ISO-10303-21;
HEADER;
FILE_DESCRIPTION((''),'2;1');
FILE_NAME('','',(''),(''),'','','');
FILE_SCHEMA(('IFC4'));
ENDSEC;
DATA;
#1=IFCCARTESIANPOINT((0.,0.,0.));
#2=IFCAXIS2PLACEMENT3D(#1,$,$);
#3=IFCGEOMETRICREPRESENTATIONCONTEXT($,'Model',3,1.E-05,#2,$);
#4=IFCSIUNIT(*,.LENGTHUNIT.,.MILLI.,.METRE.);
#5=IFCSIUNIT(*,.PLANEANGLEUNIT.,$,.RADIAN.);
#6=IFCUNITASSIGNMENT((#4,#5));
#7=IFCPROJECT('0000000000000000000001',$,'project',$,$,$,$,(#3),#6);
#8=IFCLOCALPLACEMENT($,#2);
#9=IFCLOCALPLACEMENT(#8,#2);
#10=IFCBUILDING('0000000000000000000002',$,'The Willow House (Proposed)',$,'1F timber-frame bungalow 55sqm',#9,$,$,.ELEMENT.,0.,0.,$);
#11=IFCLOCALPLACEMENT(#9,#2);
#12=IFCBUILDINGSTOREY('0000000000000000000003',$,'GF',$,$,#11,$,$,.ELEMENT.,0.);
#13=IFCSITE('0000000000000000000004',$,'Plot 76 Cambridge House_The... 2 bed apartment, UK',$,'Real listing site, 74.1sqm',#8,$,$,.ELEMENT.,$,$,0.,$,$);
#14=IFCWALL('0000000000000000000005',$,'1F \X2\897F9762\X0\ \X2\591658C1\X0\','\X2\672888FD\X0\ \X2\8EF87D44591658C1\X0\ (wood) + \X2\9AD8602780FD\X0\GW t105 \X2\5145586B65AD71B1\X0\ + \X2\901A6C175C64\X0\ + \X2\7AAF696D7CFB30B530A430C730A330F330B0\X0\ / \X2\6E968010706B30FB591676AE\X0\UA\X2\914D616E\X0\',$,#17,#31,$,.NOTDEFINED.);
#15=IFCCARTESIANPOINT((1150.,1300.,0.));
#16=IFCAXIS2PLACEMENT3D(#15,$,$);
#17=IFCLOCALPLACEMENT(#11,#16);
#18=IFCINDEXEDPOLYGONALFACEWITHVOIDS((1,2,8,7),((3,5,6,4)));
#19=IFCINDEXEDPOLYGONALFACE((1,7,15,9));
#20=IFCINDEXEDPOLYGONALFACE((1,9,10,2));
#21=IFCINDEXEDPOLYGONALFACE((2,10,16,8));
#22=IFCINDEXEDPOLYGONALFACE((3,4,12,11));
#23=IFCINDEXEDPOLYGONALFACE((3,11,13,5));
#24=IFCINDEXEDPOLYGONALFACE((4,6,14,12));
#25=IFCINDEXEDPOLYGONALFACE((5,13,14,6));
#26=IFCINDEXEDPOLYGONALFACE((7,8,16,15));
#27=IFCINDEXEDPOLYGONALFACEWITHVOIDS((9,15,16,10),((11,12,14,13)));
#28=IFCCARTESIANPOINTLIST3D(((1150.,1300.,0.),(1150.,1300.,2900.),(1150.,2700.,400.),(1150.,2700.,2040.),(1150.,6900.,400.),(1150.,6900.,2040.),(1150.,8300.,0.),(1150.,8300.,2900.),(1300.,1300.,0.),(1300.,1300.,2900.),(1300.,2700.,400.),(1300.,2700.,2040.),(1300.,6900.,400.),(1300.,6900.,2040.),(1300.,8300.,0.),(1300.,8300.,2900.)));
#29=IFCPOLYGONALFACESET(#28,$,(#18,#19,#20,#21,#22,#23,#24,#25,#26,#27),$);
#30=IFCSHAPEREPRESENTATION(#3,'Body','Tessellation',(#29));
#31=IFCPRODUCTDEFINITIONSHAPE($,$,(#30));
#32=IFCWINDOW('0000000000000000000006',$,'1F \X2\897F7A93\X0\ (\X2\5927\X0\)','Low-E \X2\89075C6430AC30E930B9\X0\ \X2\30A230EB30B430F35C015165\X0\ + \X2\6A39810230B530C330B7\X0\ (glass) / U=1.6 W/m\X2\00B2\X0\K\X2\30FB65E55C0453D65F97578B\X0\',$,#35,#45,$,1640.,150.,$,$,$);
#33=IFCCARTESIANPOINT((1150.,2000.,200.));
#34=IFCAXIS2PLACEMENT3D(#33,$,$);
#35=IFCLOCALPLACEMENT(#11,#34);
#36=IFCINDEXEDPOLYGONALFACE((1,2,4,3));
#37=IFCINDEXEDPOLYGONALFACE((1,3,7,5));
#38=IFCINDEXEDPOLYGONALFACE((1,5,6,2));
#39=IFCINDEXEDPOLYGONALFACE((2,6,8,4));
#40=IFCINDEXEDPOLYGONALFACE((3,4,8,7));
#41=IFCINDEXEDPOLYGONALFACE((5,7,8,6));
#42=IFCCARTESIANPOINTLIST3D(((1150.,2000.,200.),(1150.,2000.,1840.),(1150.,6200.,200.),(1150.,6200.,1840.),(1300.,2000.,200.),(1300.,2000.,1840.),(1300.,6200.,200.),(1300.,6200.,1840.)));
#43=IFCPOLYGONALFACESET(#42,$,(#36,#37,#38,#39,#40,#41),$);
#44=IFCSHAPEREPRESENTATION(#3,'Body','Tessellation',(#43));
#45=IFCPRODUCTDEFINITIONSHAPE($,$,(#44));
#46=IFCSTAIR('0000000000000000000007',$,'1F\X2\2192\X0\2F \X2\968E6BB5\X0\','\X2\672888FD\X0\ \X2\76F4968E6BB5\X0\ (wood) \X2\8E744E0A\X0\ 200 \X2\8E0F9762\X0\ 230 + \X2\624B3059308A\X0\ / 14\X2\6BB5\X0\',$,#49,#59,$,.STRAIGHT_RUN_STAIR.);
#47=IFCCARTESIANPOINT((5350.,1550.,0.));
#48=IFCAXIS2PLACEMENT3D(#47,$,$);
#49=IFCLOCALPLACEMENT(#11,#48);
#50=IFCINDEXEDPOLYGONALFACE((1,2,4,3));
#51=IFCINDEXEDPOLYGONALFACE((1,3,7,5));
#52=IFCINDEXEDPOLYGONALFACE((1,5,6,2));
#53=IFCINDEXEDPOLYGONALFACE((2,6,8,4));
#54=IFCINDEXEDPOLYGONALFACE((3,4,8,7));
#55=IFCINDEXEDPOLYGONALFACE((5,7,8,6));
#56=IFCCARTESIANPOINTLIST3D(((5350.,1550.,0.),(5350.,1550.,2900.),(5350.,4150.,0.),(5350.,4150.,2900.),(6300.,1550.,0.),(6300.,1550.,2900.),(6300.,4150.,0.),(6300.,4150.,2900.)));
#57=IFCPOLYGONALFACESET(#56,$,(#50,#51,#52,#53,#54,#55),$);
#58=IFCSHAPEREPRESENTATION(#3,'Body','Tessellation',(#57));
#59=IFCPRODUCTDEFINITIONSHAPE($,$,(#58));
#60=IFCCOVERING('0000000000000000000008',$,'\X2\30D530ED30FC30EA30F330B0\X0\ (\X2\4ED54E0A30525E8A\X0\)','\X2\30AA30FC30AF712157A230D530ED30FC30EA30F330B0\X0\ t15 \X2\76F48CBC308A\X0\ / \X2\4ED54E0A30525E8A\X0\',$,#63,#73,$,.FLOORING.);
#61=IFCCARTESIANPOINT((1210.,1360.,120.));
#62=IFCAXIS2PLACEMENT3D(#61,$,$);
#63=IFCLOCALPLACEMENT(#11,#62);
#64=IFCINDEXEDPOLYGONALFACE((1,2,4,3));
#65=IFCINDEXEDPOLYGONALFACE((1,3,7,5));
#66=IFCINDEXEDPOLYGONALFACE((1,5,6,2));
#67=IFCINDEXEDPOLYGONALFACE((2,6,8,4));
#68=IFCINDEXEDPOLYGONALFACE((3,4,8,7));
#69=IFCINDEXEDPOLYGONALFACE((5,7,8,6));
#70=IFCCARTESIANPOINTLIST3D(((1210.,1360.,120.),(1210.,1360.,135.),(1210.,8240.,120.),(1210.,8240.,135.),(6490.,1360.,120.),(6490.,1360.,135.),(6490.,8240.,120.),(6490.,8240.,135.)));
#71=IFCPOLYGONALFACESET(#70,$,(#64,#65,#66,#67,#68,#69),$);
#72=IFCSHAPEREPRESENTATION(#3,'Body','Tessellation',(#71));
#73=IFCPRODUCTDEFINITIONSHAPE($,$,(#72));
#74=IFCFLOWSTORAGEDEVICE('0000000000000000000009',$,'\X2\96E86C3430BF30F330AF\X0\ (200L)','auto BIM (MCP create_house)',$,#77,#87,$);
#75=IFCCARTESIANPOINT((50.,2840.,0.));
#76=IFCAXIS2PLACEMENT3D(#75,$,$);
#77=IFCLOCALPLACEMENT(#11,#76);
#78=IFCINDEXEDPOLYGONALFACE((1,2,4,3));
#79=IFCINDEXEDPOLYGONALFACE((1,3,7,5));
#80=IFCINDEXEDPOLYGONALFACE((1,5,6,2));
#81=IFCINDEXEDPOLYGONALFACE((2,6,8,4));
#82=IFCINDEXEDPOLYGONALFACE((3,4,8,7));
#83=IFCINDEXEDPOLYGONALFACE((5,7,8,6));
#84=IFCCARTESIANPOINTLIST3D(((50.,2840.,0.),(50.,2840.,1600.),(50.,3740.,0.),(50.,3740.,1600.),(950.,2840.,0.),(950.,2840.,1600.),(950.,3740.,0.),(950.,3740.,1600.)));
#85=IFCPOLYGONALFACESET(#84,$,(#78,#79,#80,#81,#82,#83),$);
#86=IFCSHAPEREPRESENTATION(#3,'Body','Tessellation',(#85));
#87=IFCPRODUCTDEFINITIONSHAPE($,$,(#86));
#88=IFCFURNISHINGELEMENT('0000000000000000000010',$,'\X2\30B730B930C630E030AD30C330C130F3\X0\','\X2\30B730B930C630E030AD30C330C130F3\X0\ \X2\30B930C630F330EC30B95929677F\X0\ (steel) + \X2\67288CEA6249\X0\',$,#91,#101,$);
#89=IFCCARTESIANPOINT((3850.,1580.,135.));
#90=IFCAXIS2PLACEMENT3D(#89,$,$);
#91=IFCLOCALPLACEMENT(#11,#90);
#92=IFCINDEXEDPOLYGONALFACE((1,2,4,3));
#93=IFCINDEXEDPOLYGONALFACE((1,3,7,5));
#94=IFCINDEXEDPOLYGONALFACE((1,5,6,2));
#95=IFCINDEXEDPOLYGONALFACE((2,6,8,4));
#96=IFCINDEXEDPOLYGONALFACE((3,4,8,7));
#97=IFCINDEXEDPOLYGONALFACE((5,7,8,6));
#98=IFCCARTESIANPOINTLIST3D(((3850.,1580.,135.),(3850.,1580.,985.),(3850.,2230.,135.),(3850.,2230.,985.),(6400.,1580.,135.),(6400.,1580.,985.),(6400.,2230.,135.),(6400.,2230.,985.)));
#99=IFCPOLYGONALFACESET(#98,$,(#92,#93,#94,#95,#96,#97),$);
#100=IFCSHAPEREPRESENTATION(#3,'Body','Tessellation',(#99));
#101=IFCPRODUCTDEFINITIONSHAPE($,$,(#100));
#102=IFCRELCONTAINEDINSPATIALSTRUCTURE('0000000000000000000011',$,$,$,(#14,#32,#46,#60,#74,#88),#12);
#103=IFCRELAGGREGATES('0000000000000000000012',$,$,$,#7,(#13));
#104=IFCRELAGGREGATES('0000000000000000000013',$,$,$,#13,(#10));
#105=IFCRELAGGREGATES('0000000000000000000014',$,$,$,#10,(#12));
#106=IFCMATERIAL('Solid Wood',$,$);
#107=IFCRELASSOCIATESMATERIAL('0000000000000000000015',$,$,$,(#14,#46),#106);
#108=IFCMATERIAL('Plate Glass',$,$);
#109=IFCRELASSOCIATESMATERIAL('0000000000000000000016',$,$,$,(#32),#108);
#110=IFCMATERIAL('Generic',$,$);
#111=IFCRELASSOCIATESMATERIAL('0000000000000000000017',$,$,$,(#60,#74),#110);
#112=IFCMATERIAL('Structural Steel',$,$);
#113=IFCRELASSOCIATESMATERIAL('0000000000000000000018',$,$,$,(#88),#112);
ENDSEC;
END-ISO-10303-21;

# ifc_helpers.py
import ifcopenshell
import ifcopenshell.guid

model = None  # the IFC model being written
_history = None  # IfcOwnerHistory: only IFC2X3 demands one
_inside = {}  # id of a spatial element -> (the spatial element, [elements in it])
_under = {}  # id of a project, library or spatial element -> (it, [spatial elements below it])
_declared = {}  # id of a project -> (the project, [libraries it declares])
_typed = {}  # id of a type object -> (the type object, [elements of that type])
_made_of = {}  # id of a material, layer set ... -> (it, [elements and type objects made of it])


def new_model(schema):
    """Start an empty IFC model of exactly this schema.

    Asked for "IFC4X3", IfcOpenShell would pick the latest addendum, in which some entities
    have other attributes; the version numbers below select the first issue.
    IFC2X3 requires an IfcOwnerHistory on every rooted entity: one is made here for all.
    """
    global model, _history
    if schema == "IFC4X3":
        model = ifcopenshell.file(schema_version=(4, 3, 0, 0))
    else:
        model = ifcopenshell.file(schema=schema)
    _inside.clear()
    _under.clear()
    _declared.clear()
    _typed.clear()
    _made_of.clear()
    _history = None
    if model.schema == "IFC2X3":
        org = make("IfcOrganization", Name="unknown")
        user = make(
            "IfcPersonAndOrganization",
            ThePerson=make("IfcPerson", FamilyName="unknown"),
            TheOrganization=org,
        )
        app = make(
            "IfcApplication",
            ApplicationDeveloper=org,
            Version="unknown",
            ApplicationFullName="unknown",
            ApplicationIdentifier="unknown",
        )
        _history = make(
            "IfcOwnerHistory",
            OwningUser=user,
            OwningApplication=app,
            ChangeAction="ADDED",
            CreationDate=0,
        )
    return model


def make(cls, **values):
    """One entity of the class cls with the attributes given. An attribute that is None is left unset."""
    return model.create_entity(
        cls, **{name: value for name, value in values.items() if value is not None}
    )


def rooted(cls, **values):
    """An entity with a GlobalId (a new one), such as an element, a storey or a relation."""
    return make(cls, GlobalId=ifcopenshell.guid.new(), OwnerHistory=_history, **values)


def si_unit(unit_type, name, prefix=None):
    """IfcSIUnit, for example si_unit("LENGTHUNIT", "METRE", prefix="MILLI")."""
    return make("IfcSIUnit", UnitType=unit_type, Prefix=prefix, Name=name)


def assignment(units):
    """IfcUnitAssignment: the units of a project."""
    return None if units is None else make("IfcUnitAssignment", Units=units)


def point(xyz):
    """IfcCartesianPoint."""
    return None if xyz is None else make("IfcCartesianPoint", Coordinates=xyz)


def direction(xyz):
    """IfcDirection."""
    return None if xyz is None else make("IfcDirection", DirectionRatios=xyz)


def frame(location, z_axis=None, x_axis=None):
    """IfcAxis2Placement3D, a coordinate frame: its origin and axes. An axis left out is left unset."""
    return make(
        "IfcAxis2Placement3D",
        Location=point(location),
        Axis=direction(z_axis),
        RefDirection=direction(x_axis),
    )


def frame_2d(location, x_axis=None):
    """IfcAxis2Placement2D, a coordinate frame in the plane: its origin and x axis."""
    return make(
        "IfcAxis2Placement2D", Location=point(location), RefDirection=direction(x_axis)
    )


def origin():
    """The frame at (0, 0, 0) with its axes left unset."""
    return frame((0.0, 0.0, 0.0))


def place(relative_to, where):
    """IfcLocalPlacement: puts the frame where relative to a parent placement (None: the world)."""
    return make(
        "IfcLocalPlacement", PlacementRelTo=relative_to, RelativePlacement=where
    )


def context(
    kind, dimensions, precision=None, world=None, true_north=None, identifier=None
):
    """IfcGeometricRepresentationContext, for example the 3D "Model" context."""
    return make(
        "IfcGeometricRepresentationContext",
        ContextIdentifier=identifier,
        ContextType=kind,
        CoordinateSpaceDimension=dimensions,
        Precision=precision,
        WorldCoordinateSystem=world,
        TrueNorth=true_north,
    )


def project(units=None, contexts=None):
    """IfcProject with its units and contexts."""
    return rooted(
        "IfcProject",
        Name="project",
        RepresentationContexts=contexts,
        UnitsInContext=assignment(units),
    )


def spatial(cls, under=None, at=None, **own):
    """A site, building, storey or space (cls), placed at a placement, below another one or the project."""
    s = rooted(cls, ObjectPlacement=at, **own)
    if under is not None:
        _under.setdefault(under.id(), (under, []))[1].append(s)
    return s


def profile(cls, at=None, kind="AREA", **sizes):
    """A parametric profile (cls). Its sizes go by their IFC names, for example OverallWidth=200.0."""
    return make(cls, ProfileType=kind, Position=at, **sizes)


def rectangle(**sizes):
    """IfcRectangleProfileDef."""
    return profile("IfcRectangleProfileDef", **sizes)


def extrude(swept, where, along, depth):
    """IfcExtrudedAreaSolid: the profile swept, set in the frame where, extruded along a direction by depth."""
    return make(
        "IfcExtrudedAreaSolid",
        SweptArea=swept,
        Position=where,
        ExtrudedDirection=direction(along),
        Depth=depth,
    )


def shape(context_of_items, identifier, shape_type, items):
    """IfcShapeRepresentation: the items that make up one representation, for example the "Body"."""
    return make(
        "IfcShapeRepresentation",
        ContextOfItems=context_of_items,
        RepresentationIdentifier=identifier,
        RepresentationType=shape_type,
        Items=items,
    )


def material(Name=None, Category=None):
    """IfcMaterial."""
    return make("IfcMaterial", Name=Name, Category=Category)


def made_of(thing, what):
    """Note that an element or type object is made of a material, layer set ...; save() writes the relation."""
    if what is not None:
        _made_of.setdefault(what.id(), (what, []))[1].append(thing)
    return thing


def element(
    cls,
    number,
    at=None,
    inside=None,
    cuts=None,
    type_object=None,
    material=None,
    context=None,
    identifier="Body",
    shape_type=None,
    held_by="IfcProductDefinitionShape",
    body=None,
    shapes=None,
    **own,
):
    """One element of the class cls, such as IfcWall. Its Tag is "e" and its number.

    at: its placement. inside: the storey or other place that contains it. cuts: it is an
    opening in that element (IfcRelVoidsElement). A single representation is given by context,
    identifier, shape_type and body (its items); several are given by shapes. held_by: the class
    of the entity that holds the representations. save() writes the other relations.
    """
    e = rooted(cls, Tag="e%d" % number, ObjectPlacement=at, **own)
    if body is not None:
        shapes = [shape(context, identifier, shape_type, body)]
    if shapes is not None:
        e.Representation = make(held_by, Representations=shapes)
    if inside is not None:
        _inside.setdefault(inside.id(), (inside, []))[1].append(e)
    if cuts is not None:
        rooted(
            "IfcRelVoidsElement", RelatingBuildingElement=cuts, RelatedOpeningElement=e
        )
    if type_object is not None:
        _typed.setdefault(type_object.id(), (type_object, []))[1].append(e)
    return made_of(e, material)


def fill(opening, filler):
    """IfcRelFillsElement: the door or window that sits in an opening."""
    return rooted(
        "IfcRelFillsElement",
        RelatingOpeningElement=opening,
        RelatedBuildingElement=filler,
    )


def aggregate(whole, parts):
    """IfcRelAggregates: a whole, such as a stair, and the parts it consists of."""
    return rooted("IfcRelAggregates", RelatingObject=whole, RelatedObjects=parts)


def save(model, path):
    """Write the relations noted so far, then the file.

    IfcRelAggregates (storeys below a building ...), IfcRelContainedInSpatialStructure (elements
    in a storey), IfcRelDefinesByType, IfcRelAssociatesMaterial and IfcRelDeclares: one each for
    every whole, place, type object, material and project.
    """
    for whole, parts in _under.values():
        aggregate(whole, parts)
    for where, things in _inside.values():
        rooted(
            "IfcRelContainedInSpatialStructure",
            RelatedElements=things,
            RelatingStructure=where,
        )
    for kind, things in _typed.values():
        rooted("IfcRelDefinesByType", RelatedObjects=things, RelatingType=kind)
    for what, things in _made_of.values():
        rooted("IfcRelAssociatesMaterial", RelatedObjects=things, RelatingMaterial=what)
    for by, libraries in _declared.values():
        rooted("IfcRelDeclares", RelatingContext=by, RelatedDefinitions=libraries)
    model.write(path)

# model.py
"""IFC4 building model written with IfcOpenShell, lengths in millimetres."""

from ifc_helpers import new_model, si_unit, frame, frame_2d, origin, place, context, project, spatial, rectangle, extrude, material, element, fill, save


model = new_model("IFC4")

# Units and contexts
model_context = context("Model", 3, precision=1e-05, world=origin())
ifc_project = project(units=[si_unit("LENGTHUNIT", "METRE", prefix="MILLI"), si_unit("PLANEANGLEUNIT", "RADIAN")], contexts=[model_context])

# Site, building, storey
site_placement = place(None, origin())
site = spatial("IfcSite", under=ifc_project, at=site_placement, Name="Plot 76 Cambridge House_The... 2 bed apartment, UK", ObjectType="Real listing site, 74.1sqm", CompositionType="ELEMENT", RefElevation=0.0)
building_placement = place(site_placement, origin())
building = spatial("IfcBuilding", under=site, at=building_placement, Name="The Willow House (Proposed)", ObjectType="1F timber-frame bungalow 55sqm", CompositionType="ELEMENT", ElevationOfRefHeight=0.0, ElevationOfTerrain=0.0)
storey_placement = place(building_placement, origin())
storey = spatial("IfcBuildingStorey", under=building, at=storey_placement, Name="GF", CompositionType="ELEMENT", Elevation=0.0)

# Shared definitions
ifc_material_1 = material(Name="Solid Wood")
ifc_material_2 = material(Name="Generic")

# Shared definitions
ifc_material_3 = material(Name="Plate Glass")

# Wall, opening, window
wall_1_placement = place(storey_placement, frame((1150.0, 1300.0, 0.0)))
wall_1 = element("IfcWall", 1, at=wall_1_placement, inside=storey, material=ifc_material_1, Name="1F 西面 外壁", Description="木製 軸組外壁 (wood) + 高性能GW t105 充填断熱 + 通気層 + 窯業系サイディング / 準耐火・外皮UA配慮", PredefinedType="NOTDEFINED", context=model_context, shape_type="SweptSolid", body=[
    extrude(rectangle(XDim=150.0, YDim=7000.0, at=frame_2d((75.0, 3500.0))), frame((1150.0, 1300.0, 0.0)), (0.0, 0.0, 1.0), 2900.0),
])
opening_1_placement = place(storey_placement, frame((1150.0, 2000.0, 200.0)))
opening_1 = element("IfcOpeningElement", 2, at=opening_1_placement, cuts=wall_1, PredefinedType="NOTDEFINED", context=model_context, shape_type="SweptSolid", body=[
    extrude(rectangle(XDim=150.0, YDim=4200.0, at=frame_2d((75.0, 2100.0))), frame((1150.0, 2000.0, 200.0)), (0.0, 0.0, 1.0), 1640.0),
])
window_1_placement = place(storey_placement, frame((1150.0, 2000.0, 200.0)))
window_1 = element("IfcWindow", 3, at=window_1_placement, inside=storey, material=ifc_material_3, Name="1F 西窓 (大)", Description="Low-E 複層ガラス アルゴン封入 + 樹脂サッシ (glass) / U=1.6 W/m²K・日射取得型", OverallHeight=1640.0, OverallWidth=150.0, context=model_context, shape_type="SweptSolid", body=[
    extrude(rectangle(XDim=150.0, YDim=4200.0, at=frame_2d((75.0, 2100.0))), frame((1150.0, 2000.0, 200.0)), (0.0, 0.0, 1.0), 1640.0),
])
fill(opening_1, window_1)

# Stair
stair_placement = place(storey_placement, frame((5350.0, 1550.0, 0.0)))
element("IfcStair", 4, at=stair_placement, inside=storey, material=ifc_material_1, Name="1F→2F 階段", Description="木製 直階段 (wood) 蹴上 200 踏面 230 + 手すり / 14段", PredefinedType="STRAIGHT_RUN_STAIR", context=model_context, shape_type="SweptSolid", body=[
    extrude(rectangle(XDim=950.0, YDim=2600.0, at=frame_2d((475.0, 1300.0))), frame((5350.0, 1550.0, 0.0)), (0.0, 0.0, 1.0), 2900.0),
])

# Covering
covering_placement = place(storey_placement, frame((1210.0, 1360.0, 120.0)))
element("IfcCovering", 5, at=covering_placement, inside=storey, material=ifc_material_2, Name="フローリング (仕上げ床)", Description="オーク無垢フローリング t15 直貼り / 仕上げ床", PredefinedType="FLOORING", context=model_context, shape_type="SweptSolid", body=[
    extrude(rectangle(XDim=5280.0, YDim=6880.0, at=frame_2d((2640.0, 3440.0))), frame((1210.0, 1360.0, 120.0)), (0.0, 0.0, 1.0), 15.0),
])

# Flow storage device
flow_storage_device_placement = place(storey_placement, frame((50.0, 2840.0, 0.0)))
element("IfcFlowStorageDevice", 6, at=flow_storage_device_placement, inside=storey, material=ifc_material_2, Name="雨水タンク (200L)", Description="auto BIM (MCP create_house)", context=model_context, shape_type="SweptSolid", body=[
    extrude(rectangle(XDim=900.0, YDim=900.0, at=frame_2d((450.0, 450.0))), frame((50.0, 2840.0, 0.0)), (0.0, 0.0, 1.0), 1600.0),
])

# Furnishing element
ifc_material_4 = material(Name="Structural Steel")
furnishing_placement = place(storey_placement, frame((3850.0, 1580.0, 135.0)))
element("IfcFurnishingElement", 7, at=furnishing_placement, inside=storey, material=ifc_material_4, Name="システムキッチン", Description="システムキッチン ステンレス天板 (steel) + 木質扉", context=model_context, shape_type="SweptSolid", body=[
    extrude(rectangle(XDim=2550.0, YDim=650.0, at=frame_2d((1275.0, 325.0))), frame((3850.0, 1580.0, 135.0)), (0.0, 0.0, 1.0), 850.0),
])

save(model, "model.ifc")
